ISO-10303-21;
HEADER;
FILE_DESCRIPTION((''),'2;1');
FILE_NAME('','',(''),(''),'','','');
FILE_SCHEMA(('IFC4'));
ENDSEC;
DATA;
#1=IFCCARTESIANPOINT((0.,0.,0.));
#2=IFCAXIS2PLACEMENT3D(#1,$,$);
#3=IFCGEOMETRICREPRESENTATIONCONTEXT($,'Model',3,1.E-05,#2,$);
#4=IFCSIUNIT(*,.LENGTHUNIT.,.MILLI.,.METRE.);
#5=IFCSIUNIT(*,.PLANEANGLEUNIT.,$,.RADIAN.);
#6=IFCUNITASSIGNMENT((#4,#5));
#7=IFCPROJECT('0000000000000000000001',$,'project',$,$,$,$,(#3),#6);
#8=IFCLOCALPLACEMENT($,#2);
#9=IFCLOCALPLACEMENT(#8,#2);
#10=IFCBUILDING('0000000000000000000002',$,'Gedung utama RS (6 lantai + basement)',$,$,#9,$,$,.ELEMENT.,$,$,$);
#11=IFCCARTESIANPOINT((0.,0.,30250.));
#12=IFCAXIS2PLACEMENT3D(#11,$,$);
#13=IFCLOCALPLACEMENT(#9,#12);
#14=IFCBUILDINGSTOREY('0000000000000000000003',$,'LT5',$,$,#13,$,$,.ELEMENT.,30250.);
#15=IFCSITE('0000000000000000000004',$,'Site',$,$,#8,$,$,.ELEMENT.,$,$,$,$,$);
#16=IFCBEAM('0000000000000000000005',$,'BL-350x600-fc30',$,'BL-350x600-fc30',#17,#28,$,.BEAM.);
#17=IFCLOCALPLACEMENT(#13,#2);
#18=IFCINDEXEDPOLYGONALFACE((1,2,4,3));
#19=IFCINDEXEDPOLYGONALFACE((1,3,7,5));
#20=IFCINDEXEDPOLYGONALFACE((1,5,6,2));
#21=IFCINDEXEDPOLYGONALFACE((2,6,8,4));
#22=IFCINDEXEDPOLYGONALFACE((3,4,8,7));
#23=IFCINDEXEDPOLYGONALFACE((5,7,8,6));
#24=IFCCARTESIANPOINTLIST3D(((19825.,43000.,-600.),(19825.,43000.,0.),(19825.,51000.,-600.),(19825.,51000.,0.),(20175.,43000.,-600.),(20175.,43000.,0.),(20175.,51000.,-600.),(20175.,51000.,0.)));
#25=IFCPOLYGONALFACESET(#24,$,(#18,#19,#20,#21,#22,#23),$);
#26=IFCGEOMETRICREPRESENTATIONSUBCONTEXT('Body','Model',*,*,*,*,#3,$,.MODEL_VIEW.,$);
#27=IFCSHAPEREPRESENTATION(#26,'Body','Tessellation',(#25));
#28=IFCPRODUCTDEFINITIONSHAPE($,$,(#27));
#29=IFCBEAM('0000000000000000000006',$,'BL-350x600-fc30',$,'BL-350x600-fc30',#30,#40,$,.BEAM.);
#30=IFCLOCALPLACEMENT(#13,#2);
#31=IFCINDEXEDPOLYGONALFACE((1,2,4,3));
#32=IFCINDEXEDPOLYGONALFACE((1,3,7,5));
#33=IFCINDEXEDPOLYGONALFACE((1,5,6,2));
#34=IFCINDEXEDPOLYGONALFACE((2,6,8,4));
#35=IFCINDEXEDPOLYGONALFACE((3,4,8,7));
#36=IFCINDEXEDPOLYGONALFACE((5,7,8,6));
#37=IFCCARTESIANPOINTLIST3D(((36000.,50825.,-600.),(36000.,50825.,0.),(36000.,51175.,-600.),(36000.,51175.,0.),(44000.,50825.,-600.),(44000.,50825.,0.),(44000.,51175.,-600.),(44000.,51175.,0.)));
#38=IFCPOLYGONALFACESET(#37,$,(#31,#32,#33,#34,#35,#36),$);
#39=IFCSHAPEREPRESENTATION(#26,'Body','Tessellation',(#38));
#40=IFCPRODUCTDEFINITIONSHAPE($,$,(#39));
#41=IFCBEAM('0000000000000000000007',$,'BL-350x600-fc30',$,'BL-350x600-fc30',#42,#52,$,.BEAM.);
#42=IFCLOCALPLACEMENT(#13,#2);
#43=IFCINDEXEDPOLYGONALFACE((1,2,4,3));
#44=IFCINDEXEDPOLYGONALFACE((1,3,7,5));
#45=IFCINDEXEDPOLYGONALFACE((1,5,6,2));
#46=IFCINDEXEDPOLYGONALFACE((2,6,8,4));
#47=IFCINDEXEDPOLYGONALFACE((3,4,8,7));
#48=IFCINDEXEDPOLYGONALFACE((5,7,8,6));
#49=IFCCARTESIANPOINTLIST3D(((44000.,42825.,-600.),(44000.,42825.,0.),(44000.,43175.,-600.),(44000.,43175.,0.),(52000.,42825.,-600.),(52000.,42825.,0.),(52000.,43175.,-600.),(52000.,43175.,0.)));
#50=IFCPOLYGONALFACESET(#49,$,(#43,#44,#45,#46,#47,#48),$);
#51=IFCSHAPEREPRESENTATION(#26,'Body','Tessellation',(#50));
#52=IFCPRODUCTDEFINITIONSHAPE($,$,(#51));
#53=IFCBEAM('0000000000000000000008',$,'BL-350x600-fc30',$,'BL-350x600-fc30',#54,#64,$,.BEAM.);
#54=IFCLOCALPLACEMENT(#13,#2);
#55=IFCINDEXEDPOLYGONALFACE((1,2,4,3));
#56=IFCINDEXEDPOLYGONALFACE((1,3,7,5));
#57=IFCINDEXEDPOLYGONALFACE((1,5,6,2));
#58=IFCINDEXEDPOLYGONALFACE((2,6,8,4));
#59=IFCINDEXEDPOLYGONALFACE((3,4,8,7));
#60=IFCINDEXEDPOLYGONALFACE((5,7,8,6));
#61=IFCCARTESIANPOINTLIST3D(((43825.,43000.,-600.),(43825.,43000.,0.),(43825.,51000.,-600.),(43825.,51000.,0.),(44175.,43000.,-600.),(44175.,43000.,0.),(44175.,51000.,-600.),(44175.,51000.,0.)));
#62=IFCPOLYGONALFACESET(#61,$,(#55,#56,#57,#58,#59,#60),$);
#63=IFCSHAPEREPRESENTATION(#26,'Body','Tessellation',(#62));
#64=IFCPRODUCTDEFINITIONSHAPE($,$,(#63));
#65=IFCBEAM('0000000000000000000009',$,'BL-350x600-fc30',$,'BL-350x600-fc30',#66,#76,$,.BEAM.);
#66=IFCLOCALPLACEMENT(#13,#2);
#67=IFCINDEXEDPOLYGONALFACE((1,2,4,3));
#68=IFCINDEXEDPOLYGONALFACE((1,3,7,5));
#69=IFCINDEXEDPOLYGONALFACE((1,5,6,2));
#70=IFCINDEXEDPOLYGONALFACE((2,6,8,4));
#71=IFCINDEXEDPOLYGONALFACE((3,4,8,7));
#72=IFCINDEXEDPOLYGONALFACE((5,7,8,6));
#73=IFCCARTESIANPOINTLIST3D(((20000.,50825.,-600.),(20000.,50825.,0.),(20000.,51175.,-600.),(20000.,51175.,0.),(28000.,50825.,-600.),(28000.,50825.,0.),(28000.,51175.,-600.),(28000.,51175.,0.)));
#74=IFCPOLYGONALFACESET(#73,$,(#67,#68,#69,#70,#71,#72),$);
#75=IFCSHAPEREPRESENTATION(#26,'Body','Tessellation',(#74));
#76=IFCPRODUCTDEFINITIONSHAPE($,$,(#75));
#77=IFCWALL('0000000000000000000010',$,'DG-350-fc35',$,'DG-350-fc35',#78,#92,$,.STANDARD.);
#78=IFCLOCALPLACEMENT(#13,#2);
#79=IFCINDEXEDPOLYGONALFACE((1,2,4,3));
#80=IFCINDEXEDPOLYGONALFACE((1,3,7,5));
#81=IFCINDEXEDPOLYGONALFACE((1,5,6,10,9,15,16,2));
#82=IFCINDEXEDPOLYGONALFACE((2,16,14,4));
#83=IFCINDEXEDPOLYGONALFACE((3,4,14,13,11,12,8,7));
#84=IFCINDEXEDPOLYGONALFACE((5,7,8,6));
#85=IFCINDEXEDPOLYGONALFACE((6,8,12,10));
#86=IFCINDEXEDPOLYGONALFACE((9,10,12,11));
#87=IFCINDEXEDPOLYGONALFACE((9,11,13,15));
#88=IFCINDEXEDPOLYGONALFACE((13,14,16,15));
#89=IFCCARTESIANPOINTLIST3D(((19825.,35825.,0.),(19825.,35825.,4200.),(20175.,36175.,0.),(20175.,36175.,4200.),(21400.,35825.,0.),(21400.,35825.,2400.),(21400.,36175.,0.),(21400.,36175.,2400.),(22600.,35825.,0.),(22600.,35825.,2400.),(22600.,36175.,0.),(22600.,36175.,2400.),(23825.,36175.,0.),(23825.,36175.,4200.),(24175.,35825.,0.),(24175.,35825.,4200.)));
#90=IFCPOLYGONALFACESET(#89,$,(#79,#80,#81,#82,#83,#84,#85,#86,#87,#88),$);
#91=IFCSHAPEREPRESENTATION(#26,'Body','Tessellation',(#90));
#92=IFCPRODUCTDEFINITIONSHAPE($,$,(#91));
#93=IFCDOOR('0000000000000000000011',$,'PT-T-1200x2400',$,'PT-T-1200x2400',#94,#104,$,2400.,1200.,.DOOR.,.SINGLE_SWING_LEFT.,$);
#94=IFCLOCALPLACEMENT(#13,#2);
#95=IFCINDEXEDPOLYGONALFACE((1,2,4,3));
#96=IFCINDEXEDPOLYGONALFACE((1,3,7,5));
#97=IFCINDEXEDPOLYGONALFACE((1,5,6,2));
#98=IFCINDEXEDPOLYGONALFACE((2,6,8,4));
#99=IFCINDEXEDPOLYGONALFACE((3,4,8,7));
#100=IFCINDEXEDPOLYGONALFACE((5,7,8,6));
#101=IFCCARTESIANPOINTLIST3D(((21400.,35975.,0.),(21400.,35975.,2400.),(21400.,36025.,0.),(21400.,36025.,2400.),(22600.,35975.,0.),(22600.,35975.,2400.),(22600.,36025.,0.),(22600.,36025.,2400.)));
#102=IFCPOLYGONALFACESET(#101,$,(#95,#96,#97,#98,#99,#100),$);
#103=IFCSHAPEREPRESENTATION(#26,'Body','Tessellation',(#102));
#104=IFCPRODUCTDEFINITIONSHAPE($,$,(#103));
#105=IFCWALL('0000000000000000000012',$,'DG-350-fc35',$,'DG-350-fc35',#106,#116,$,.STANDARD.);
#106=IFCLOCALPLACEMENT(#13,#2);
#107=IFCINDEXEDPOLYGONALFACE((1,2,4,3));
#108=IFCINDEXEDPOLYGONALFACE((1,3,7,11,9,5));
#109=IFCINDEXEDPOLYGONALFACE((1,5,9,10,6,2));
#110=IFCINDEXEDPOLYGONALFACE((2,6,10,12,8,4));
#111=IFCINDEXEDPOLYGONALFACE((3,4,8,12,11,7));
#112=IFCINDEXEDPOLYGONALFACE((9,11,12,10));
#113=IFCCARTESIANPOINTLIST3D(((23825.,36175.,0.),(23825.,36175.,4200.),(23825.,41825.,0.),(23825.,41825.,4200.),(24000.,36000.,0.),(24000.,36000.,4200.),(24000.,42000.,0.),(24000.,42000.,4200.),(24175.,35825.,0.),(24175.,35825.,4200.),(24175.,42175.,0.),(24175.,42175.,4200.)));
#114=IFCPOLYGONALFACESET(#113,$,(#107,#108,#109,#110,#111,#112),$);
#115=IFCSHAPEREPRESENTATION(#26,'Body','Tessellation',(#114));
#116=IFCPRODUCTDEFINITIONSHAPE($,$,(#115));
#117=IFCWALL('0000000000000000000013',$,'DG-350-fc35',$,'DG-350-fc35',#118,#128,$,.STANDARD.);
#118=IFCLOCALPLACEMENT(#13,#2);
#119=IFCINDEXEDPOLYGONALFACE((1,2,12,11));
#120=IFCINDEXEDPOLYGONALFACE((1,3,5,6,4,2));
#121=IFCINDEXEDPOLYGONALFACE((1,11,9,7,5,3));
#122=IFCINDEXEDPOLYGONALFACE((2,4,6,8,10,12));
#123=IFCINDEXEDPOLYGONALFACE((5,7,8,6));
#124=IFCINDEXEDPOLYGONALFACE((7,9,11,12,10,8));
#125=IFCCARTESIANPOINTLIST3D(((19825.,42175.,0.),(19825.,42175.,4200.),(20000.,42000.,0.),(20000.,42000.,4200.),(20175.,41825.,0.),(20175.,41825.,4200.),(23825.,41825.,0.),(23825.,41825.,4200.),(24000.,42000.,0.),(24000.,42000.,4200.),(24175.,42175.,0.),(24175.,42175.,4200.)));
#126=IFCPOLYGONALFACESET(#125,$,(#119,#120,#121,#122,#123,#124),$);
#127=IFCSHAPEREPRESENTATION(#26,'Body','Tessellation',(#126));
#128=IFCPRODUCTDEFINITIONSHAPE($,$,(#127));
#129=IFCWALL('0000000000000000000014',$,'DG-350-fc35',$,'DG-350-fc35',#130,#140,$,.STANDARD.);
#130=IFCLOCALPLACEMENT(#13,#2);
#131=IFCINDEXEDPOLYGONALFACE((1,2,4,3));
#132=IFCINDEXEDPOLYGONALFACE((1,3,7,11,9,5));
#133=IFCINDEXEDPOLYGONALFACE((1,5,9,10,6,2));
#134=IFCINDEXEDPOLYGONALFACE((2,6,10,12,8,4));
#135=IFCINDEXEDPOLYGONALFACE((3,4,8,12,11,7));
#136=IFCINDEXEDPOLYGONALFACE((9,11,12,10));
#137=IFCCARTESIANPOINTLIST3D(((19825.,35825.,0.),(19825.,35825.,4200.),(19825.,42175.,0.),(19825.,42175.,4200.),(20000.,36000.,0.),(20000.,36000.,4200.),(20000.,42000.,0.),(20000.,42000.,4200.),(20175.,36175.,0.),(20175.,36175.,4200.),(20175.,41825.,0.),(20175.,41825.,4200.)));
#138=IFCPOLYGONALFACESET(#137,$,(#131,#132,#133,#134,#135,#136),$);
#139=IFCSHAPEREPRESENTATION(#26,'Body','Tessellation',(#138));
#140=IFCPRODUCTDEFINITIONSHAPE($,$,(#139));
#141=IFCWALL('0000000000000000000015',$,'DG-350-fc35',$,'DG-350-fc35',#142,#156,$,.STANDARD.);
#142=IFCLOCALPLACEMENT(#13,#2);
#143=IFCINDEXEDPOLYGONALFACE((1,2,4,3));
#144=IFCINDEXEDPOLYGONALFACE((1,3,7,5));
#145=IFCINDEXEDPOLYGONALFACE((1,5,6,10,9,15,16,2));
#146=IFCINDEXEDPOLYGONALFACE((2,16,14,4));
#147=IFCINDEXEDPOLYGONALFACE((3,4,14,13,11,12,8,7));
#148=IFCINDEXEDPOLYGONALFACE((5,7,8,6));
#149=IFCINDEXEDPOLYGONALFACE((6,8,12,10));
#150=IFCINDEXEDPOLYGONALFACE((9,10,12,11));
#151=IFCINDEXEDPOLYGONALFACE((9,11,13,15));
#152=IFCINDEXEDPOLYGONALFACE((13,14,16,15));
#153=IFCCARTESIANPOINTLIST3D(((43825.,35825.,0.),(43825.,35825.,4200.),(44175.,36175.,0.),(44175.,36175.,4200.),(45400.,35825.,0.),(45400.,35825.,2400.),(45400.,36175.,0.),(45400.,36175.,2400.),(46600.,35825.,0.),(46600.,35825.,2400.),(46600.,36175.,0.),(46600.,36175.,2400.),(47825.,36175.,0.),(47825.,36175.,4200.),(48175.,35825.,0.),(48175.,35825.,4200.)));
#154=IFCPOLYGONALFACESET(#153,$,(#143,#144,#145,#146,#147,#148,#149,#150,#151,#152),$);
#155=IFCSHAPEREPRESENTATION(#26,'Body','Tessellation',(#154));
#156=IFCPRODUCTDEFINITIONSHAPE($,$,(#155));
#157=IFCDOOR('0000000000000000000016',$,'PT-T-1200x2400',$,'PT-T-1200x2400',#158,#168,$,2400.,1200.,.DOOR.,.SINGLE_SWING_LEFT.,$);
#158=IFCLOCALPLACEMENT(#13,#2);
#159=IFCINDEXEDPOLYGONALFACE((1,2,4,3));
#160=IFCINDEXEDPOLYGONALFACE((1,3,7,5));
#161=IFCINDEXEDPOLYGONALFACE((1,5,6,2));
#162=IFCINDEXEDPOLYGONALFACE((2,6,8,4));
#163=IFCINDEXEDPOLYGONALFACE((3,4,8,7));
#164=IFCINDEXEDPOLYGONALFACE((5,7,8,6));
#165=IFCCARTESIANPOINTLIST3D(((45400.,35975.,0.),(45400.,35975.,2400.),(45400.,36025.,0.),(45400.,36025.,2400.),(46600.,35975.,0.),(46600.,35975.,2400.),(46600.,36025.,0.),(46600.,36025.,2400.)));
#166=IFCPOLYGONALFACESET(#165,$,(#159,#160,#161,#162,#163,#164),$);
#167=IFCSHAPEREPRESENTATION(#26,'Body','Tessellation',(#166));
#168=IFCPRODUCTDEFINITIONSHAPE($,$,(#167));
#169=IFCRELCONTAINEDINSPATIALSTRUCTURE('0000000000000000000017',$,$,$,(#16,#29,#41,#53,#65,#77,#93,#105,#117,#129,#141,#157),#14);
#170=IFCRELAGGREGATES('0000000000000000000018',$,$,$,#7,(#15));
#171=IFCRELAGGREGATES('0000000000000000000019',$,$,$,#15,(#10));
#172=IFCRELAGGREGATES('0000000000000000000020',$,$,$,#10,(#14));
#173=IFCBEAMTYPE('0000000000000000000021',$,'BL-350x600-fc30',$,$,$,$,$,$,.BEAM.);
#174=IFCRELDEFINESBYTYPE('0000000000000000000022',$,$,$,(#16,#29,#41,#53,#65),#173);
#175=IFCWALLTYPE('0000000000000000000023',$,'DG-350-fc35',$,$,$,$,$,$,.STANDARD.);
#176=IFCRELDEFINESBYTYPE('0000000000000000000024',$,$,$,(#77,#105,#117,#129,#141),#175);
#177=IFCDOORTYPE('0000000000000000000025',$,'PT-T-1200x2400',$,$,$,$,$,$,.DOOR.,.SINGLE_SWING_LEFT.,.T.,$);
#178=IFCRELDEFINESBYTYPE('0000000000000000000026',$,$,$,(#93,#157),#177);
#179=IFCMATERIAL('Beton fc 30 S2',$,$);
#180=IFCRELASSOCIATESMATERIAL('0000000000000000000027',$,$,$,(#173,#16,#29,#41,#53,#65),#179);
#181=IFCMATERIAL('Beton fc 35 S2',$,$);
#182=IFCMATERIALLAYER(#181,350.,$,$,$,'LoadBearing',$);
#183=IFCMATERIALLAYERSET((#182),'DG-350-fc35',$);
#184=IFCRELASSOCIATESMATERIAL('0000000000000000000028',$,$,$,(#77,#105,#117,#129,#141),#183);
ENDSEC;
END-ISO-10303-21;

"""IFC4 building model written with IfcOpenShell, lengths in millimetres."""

from ifc_helpers import new_model, si_unit, frame, frame_2d, origin, origin_2d, place, context, subcontext, project, spatial, polyline, rectangle, outline, extrude, material, layer, layer_set, layer_usage, material_profile, profile_set, profile_usage, type_object, element, fill, save


model = new_model("IFC4")

# Units and contexts
model_context = context("Model", 3, precision=1e-05, world=origin())
body_context = subcontext(model_context, "Body", "Model", "MODEL_VIEW")
ifc_project = project(units=[si_unit("LENGTHUNIT", "METRE", prefix="MILLI"), si_unit("PLANEANGLEUNIT", "RADIAN")], contexts=[model_context])

# Site, building, storey
site_placement = place(None, origin())
site = spatial("IfcSite", under=ifc_project, at=site_placement, Name="Site", CompositionType="ELEMENT")
building_placement = place(site_placement, origin())
building = spatial("IfcBuilding", under=site, at=building_placement, Name="Gedung utama RS (6 lantai + basement)", CompositionType="ELEMENT")
storey_placement = place(building_placement, frame((0.0, 0.0, 30250.0)))
storey = spatial("IfcBuildingStorey", under=building, at=storey_placement, Name="LT5", CompositionType="ELEMENT", Elevation=30250.0)

# Beams
ifc_material_1 = material(Name="Beton fc 30 S2")
ifc_material_profile_1 = material_profile(ifc_material_1, rectangle(XDim=350.0, YDim=600.0, at=origin_2d()), Name="BL-350x600-fc30")
ifc_profile_set_1 = profile_set([ifc_material_profile_1], Name="BL-350x600-fc30")
ifc_profile_usage_1 = profile_usage(ifc_profile_set_1, cardinal=8)
beam_type = type_object("IfcBeamType", Name="BL-350x600-fc30", PredefinedType="BEAM", material=ifc_profile_set_1)
beam_1_placement = place(storey_placement, frame((20000.0, 43000.0, -300.0)))
element("IfcBeam", 1, at=beam_1_placement, inside=storey, type_object=beam_type, material=ifc_profile_usage_1, Name="BL-350x600-fc30", ObjectType="BL-350x600-fc30", PredefinedType="BEAM", context=body_context, shape_type="SweptSolid", body=[
    extrude(rectangle(XDim=350.0, YDim=600.0, at=origin_2d()), frame((0.0, 0.0, 0.0), z_axis=(0.0, 1.0, 0.0), x_axis=(-1.0, 0.0, 0.0)), (0.0, 0.0, 1.0), 8000.0),
])
for number, where, name in (
    (2, (36000.0, 51000.0, -300.0), "BL-350x600-fc30"),
    (3, (44000.0, 43000.0, -300.0), "BL-350x600-fc30"),
):
    element("IfcBeam", number, at=place(storey_placement, frame(where)), inside=storey, type_object=beam_type, material=ifc_profile_usage_1, Name=name, ObjectType="BL-350x600-fc30", PredefinedType="BEAM", context=body_context, shape_type="SweptSolid", body=[
        extrude(rectangle(XDim=350.0, YDim=600.0, at=origin_2d()), frame((0.0, 0.0, 0.0), z_axis=(1.0, 0.0, 0.0), x_axis=(0.0, 1.0, 0.0)), (0.0, 0.0, 1.0), 8000.0),
    ])
beam_2_placement = place(storey_placement, frame((44000.0, 43000.0, -300.0)))
element("IfcBeam", 4, at=beam_2_placement, inside=storey, type_object=beam_type, material=ifc_profile_usage_1, Name="BL-350x600-fc30", ObjectType="BL-350x600-fc30", PredefinedType="BEAM", context=body_context, shape_type="SweptSolid", body=[
    extrude(rectangle(XDim=350.0, YDim=600.0, at=origin_2d()), frame((0.0, 0.0, 0.0), z_axis=(0.0, 1.0, 0.0), x_axis=(-1.0, 0.0, 0.0)), (0.0, 0.0, 1.0), 8000.0),
])
beam_3_placement = place(storey_placement, frame((20000.0, 51000.0, -300.0)))
element("IfcBeam", 5, at=beam_3_placement, inside=storey, type_object=beam_type, material=ifc_profile_usage_1, Name="BL-350x600-fc30", ObjectType="BL-350x600-fc30", PredefinedType="BEAM", context=body_context, shape_type="SweptSolid", body=[
    extrude(rectangle(XDim=350.0, YDim=600.0, at=origin_2d()), frame((0.0, 0.0, 0.0), z_axis=(1.0, 0.0, 0.0), x_axis=(0.0, 1.0, 0.0)), (0.0, 0.0, 1.0), 8000.0),
])

# Wall, opening, door
ifc_material_2 = material(Name="Beton fc 35 S2")
ifc_layer = layer(ifc_material_2, 350.0, Category="LoadBearing")
ifc_layer_set = layer_set([ifc_layer], Name="DG-350-fc35")
ifc_layer_usage = layer_usage(ifc_layer_set, "AXIS2", "NEGATIVE", 175.0)
wall_type = type_object("IfcWallType", Name="DG-350-fc35", PredefinedType="STANDARD")
wall_1_placement = place(storey_placement, frame((20000.0, 36000.0, 0.0), z_axis=(0.0, 0.0, 1.0), x_axis=(1.0, 0.0, 0.0)))
wall_1 = element("IfcWall", 6, at=wall_1_placement, inside=storey, type_object=wall_type, material=ifc_layer_usage, Name="DG-350-fc35", ObjectType="DG-350-fc35", PredefinedType="STANDARD", context=body_context, shape_type="SweptSolid", body=[
    extrude(outline(polyline([(-175.0, -175.0), (0.0, 0.0), (175.0, 175.0), (3825.0, 175.0), (4000.0, 0.0), (4175.0, -175.0), (-175.0, -175.0)])), origin(), (0.0, 0.0, 1.0), 4200.0),
])
opening_1_placement = place(wall_1_placement, frame((1400.0, 0.0, 0.0), z_axis=(0.0, 0.0, 1.0), x_axis=(1.0, 0.0, 0.0)))
opening_1 = element("IfcOpeningElement", 7, at=opening_1_placement, cuts=wall_1, PredefinedType="OPENING", context=body_context, shape_type="SweptSolid", body=[
    extrude(rectangle(XDim=1200.0, YDim=370.0, at=frame_2d((600.0, 0.0))), origin(), (0.0, 0.0, 1.0), 2400.0),
])
door_type = type_object("IfcDoorType", Name="PT-T-1200x2400", OperationType="SINGLE_SWING_LEFT", ParameterTakesPrecedence=True, PredefinedType="DOOR")
door_1_placement = place(opening_1_placement, origin())
door_1 = element("IfcDoor", 8, at=door_1_placement, inside=storey, type_object=door_type, Name="PT-T-1200x2400", ObjectType="PT-T-1200x2400", OperationType="SINGLE_SWING_LEFT", OverallHeight=2400.0, OverallWidth=1200.0, PredefinedType="DOOR", context=body_context, shape_type="SweptSolid", body=[
    extrude(rectangle(XDim=1200.0, YDim=50.0, at=frame_2d((600.0, 0.0))), origin(), (0.0, 0.0, 1.0), 2400.0),
])
fill(opening_1, door_1)

# Walls
wall_2_placement = place(storey_placement, frame((24000.0, 36000.0, 0.0), z_axis=(0.0, 0.0, 1.0), x_axis=(0.0, 1.0, 0.0)))
element("IfcWall", 9, at=wall_2_placement, inside=storey, type_object=wall_type, material=ifc_layer_usage, Name="DG-350-fc35", ObjectType="DG-350-fc35", PredefinedType="STANDARD", context=body_context, shape_type="SweptSolid", body=[
    extrude(outline(polyline([(-175.0, -175.0), (0.0, 0.0), (175.0, 175.0), (5825.0, 175.0), (6000.0, 0.0), (6175.0, -175.0), (-175.0, -175.0)])), origin(), (0.0, 0.0, 1.0), 4200.0),
])
wall_3_placement = place(storey_placement, frame((24000.0, 42000.0, 0.0), z_axis=(0.0, 0.0, 1.0), x_axis=(-1.0, 0.0, 0.0)))
element("IfcWall", 10, at=wall_3_placement, inside=storey, type_object=wall_type, material=ifc_layer_usage, Name="DG-350-fc35", ObjectType="DG-350-fc35", PredefinedType="STANDARD", context=body_context, shape_type="SweptSolid", body=[
    extrude(outline(polyline([(-175.0, -175.0), (0.0, 0.0), (175.0, 175.0), (3825.0, 175.0), (4000.0, 0.0), (4175.0, -175.0), (-175.0, -175.0)])), origin(), (0.0, 0.0, 1.0), 4200.0),
])
wall_4_placement = place(storey_placement, frame((20000.0, 42000.0, 0.0), z_axis=(0.0, 0.0, 1.0), x_axis=(0.0, -1.0, 0.0)))
element("IfcWall", 11, at=wall_4_placement, inside=storey, type_object=wall_type, material=ifc_layer_usage, Name="DG-350-fc35", ObjectType="DG-350-fc35", PredefinedType="STANDARD", context=body_context, shape_type="SweptSolid", body=[
    extrude(outline(polyline([(-175.0, -175.0), (0.0, 0.0), (175.0, 175.0), (5825.0, 175.0), (6000.0, 0.0), (6175.0, -175.0), (-175.0, -175.0)])), origin(), (0.0, 0.0, 1.0), 4200.0),
])

# Wall, opening, door
wall_5_placement = place(storey_placement, frame((44000.0, 36000.0, 0.0), z_axis=(0.0, 0.0, 1.0), x_axis=(1.0, 0.0, 0.0)))
wall_5 = element("IfcWall", 12, at=wall_5_placement, inside=storey, type_object=wall_type, material=ifc_layer_usage, Name="DG-350-fc35", ObjectType="DG-350-fc35", PredefinedType="STANDARD", context=body_context, shape_type="SweptSolid", body=[
    extrude(outline(polyline([(-175.0, -175.0), (0.0, 0.0), (175.0, 175.0), (3825.0, 175.0), (4000.0, 0.0), (4175.0, -175.0), (-175.0, -175.0)])), origin(), (0.0, 0.0, 1.0), 4200.0),
])
opening_2_placement = place(wall_5_placement, frame((1400.0, 0.0, 0.0), z_axis=(0.0, 0.0, 1.0), x_axis=(1.0, 0.0, 0.0)))
opening_2 = element("IfcOpeningElement", 13, at=opening_2_placement, cuts=wall_5, PredefinedType="OPENING", context=body_context, shape_type="SweptSolid", body=[
    extrude(rectangle(XDim=1200.0, YDim=370.0, at=frame_2d((600.0, 0.0))), origin(), (0.0, 0.0, 1.0), 2400.0),
])
door_2_placement = place(opening_2_placement, origin())
door_2 = element("IfcDoor", 14, at=door_2_placement, inside=storey, type_object=door_type, Name="PT-T-1200x2400", ObjectType="PT-T-1200x2400", OperationType="SINGLE_SWING_LEFT", OverallHeight=2400.0, OverallWidth=1200.0, PredefinedType="DOOR", context=body_context, shape_type="SweptSolid", body=[
    extrude(rectangle(XDim=1200.0, YDim=50.0, at=frame_2d((600.0, 0.0))), origin(), (0.0, 0.0, 1.0), 2400.0),
])
fill(opening_2, door_2)

save(model, "model.ifc")
